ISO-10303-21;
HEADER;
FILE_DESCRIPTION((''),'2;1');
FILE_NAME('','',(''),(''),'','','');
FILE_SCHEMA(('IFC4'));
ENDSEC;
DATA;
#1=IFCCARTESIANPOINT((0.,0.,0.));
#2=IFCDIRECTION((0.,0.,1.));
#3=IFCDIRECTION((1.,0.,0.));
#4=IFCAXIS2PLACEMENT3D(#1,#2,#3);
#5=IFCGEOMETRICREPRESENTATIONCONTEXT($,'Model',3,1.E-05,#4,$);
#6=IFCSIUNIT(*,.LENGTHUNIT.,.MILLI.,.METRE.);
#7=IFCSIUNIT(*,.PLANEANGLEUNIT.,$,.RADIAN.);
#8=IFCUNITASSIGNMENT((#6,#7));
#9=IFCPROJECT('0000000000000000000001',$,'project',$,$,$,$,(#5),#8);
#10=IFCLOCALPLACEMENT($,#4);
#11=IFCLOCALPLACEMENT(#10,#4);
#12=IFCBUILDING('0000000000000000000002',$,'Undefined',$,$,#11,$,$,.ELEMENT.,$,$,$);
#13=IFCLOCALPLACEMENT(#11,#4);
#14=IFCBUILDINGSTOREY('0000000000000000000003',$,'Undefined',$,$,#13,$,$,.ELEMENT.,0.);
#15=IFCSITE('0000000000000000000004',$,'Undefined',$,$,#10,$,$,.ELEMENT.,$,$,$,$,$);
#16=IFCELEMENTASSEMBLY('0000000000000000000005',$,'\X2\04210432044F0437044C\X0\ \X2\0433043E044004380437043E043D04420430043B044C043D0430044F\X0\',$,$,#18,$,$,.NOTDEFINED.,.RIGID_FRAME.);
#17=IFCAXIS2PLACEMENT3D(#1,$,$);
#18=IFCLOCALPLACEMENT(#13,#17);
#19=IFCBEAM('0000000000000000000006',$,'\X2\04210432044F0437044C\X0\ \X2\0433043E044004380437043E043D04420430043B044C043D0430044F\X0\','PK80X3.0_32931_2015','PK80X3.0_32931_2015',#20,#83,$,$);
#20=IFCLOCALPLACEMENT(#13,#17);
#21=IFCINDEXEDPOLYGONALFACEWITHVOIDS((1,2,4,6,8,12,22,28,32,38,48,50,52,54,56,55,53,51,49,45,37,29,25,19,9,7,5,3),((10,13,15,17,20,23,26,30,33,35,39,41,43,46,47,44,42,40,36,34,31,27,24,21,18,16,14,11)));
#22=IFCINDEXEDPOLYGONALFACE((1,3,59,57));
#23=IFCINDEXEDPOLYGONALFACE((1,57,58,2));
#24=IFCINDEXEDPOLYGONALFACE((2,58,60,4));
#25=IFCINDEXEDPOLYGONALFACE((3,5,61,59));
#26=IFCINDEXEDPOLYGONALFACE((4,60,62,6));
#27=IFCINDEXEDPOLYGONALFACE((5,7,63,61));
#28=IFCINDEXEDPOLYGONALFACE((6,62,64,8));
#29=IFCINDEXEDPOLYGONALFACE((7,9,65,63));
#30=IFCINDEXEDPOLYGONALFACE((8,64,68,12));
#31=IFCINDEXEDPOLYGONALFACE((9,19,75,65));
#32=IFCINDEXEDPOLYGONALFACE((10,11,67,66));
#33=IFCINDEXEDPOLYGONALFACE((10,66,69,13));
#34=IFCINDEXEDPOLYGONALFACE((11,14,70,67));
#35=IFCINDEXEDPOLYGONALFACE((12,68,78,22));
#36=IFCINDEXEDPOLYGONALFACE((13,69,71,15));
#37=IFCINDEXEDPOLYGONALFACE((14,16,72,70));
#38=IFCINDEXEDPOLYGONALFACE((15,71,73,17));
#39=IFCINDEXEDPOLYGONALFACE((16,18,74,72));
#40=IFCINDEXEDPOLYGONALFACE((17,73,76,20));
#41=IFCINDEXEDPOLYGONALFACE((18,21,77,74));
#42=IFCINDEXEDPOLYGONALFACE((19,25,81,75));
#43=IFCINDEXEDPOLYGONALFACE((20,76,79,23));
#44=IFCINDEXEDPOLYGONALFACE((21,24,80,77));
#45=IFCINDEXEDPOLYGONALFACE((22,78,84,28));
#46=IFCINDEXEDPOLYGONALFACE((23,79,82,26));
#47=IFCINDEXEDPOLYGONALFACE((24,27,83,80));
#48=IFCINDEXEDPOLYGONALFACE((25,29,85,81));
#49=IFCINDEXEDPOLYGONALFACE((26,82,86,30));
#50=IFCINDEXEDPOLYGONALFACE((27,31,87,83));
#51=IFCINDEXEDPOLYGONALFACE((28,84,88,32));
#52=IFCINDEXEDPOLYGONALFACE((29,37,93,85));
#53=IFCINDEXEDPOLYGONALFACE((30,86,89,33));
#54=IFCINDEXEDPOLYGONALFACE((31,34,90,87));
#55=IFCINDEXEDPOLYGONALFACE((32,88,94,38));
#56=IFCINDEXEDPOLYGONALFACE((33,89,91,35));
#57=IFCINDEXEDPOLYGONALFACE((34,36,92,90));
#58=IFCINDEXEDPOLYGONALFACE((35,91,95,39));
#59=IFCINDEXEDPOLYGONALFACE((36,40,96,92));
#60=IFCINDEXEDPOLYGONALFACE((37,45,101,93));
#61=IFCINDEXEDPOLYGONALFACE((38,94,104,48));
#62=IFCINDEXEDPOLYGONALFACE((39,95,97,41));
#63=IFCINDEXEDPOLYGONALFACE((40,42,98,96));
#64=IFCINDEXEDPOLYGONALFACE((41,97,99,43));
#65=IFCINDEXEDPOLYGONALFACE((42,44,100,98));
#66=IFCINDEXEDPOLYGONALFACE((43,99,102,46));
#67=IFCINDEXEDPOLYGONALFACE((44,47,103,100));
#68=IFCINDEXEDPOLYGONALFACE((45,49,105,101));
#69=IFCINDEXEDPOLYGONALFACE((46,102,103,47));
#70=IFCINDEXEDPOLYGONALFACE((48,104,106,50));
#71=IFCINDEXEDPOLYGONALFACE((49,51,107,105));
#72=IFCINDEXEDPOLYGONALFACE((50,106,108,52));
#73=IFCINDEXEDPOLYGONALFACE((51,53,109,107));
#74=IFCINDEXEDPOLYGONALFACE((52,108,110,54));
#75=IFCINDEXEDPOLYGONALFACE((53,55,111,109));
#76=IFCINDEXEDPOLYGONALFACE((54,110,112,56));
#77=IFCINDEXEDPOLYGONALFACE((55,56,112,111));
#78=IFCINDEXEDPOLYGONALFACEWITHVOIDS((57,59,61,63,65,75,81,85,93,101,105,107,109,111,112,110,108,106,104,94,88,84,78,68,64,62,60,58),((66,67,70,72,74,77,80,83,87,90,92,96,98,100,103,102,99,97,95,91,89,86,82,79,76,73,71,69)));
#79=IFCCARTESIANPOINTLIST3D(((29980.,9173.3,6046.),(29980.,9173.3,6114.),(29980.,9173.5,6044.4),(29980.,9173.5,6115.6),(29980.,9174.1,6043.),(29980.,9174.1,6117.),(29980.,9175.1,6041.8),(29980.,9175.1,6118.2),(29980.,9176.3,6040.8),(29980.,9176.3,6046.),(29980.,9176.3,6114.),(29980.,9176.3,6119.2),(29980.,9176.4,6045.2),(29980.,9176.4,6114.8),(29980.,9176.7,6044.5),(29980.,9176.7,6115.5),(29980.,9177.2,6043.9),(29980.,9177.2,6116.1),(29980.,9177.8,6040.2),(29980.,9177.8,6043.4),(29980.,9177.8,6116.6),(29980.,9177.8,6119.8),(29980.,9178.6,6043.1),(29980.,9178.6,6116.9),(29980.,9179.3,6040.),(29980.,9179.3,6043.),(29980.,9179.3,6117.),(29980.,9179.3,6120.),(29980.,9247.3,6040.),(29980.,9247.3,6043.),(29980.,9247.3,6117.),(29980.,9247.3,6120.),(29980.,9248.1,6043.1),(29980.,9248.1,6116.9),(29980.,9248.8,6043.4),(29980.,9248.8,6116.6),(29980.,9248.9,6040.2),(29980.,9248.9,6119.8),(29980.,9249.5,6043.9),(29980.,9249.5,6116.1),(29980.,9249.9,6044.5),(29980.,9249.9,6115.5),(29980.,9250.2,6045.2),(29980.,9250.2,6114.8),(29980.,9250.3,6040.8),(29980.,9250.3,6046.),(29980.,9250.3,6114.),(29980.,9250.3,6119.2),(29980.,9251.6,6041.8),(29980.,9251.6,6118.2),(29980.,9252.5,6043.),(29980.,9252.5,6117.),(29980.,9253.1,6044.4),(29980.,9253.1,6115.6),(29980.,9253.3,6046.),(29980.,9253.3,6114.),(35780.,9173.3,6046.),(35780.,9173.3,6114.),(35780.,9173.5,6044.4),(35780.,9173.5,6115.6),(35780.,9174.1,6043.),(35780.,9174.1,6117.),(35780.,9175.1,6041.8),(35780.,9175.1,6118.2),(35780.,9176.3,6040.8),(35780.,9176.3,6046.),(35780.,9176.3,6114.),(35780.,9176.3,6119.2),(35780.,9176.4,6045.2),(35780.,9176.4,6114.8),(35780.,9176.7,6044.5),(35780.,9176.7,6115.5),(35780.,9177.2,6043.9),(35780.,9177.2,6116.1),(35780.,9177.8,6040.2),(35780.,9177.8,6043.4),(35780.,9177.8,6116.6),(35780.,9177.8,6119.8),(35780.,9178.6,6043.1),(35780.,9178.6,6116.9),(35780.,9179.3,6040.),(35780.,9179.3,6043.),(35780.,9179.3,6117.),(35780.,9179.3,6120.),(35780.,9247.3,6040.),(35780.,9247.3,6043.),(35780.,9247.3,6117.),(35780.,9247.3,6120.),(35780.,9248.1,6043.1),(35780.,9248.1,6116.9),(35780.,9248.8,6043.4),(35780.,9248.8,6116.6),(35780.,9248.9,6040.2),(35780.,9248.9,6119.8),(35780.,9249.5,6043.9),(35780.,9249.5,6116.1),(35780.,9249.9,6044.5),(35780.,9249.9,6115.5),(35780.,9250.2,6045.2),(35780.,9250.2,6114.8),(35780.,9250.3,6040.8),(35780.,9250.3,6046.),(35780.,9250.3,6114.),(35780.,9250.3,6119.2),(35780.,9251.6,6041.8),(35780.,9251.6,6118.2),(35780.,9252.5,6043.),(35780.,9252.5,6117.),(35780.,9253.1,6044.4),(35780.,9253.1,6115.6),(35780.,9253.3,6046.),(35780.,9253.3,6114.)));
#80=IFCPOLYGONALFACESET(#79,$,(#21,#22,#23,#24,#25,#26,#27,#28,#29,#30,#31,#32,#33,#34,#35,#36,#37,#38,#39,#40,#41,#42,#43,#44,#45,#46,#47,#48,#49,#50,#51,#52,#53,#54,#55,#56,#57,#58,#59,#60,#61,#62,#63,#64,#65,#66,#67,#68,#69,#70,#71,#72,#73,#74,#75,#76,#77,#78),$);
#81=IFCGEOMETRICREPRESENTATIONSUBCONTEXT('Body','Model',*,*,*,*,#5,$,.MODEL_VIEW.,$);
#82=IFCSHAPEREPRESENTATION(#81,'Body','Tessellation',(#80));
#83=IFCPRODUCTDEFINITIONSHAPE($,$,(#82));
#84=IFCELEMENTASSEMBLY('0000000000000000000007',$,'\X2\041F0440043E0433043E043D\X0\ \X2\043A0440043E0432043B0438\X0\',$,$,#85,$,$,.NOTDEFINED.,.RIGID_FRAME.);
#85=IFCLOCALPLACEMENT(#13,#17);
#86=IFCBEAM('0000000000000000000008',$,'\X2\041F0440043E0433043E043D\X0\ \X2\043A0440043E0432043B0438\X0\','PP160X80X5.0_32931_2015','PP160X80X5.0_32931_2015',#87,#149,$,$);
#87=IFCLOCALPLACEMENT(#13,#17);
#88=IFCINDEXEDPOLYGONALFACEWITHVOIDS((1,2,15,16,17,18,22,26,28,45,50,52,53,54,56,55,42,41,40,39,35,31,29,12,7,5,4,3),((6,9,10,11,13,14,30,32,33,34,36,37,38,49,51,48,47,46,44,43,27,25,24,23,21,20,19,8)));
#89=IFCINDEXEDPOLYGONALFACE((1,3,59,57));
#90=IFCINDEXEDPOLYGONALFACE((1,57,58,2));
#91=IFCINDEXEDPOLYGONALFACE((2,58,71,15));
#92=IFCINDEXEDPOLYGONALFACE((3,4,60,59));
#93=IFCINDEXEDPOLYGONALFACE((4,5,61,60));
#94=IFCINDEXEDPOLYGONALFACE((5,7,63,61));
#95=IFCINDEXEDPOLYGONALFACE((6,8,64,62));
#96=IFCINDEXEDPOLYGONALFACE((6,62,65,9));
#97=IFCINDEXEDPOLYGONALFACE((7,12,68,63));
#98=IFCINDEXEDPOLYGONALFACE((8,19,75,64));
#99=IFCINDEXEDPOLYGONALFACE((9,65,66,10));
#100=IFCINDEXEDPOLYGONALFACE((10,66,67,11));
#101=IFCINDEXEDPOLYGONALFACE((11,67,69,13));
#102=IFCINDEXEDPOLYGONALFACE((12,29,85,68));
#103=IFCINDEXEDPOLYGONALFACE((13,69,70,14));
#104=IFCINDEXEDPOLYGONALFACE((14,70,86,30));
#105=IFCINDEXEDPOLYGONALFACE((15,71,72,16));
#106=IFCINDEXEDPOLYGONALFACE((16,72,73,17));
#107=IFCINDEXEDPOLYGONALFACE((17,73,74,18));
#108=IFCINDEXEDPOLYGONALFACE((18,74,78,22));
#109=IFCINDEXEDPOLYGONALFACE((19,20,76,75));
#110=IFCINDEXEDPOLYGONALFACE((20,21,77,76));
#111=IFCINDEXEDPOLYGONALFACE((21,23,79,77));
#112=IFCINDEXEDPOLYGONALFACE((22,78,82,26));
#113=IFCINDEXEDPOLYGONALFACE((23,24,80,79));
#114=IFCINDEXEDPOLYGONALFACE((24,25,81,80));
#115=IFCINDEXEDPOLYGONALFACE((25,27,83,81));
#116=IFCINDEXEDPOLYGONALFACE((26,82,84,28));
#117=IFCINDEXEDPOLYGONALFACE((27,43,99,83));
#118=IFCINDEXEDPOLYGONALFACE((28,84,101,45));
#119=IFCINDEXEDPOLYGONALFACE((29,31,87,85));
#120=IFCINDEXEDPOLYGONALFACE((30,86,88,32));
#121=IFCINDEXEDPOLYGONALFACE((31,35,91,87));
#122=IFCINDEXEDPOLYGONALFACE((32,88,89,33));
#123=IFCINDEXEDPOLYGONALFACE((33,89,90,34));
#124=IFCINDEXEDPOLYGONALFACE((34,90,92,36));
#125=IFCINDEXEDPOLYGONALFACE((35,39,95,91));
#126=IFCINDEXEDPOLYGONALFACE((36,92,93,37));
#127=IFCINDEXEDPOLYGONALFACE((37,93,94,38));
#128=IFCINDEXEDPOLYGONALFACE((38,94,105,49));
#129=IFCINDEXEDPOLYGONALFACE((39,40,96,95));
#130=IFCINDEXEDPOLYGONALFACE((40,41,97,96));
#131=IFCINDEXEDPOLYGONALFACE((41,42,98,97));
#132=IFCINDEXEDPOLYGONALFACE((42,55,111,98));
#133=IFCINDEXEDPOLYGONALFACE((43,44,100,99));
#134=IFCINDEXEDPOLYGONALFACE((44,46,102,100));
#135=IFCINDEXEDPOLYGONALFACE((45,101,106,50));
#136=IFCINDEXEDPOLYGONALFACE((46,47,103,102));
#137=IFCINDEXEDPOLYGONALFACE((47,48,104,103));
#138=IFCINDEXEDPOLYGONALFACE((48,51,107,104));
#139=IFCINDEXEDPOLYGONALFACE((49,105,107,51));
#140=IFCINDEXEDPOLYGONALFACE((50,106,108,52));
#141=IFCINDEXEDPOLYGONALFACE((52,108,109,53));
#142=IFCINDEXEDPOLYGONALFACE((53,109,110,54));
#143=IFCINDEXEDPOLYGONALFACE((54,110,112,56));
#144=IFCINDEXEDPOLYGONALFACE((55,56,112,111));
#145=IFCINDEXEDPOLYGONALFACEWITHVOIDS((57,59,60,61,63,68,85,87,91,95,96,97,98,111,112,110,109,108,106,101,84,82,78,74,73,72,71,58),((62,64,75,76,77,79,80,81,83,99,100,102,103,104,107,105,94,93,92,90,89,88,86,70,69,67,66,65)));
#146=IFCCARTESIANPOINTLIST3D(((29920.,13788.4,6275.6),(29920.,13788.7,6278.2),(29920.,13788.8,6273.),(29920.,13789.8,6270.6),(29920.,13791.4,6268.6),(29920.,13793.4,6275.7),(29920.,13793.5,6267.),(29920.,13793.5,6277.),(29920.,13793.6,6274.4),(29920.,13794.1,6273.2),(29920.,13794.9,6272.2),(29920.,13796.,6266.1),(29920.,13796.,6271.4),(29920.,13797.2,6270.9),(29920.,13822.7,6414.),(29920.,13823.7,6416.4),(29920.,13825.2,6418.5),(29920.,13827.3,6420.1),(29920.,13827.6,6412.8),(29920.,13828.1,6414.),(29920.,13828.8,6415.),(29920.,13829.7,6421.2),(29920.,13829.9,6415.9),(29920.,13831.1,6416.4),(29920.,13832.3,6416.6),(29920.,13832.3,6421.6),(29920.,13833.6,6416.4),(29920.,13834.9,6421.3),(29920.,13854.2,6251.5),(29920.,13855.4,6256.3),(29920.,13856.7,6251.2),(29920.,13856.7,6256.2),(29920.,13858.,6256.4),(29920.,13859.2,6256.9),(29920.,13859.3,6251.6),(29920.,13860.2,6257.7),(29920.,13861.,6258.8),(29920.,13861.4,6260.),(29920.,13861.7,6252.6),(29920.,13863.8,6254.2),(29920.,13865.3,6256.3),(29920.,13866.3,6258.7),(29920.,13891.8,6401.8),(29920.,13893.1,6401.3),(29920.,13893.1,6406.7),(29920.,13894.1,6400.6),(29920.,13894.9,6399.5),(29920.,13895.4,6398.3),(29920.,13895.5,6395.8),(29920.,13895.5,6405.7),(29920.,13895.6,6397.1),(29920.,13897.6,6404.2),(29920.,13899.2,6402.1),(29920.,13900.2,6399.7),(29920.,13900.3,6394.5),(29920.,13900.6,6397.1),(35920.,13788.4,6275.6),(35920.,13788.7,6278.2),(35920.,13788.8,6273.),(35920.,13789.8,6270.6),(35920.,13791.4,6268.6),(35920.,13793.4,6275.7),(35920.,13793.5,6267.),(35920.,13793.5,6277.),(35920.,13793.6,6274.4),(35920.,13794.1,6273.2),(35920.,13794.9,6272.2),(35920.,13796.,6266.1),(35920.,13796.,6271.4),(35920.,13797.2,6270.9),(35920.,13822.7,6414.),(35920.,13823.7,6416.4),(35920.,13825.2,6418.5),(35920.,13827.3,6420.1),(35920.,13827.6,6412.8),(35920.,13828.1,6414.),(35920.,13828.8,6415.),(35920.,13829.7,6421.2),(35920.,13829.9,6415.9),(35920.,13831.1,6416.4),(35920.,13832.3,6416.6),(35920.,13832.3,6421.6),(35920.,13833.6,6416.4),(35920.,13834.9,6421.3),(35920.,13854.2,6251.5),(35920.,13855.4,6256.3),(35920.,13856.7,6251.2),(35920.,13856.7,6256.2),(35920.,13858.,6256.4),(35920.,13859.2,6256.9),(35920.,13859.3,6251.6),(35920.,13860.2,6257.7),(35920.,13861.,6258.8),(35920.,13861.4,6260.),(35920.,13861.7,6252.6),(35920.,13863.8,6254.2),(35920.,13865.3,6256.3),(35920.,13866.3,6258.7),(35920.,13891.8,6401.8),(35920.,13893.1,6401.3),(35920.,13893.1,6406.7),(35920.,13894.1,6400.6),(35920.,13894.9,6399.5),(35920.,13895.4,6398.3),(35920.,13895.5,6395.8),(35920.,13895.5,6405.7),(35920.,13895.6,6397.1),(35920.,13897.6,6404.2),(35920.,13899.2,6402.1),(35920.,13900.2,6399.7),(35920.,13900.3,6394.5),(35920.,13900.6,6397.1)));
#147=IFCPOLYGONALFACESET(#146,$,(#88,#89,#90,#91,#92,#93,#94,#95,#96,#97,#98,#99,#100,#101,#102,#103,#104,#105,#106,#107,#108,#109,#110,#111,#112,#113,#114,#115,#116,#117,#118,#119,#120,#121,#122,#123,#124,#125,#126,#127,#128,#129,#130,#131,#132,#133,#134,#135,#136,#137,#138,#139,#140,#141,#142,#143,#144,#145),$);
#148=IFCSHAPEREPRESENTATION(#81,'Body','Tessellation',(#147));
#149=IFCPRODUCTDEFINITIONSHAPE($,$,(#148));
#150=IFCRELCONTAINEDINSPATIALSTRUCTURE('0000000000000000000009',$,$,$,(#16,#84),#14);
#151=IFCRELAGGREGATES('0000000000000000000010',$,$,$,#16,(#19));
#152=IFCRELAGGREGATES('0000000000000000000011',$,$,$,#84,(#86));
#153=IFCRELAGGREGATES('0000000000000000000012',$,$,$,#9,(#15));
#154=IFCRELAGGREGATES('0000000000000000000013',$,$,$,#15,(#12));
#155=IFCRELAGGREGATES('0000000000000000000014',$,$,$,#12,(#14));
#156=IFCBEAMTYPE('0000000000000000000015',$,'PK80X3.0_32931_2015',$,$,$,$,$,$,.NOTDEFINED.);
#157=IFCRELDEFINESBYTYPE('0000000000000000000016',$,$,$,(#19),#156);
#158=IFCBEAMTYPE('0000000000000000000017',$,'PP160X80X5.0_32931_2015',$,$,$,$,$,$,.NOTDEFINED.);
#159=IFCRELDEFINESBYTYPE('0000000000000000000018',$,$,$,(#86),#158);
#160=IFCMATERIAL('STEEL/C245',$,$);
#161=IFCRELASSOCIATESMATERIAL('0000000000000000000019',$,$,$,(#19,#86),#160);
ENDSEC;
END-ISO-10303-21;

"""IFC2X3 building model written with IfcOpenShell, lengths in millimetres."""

from ifc_helpers import new_model, si_unit, frame, origin_with_axes, origin_2d_with_axis, place, context, subcontext, project, spatial, hollow_rectangle, extrude, material, type_object, element, aggregate, save


model = new_model("IFC2X3")

# Units and contexts
model_context = context("Model", 3, precision=1e-05, world=origin_with_axes())
body_context = subcontext(model_context, "Body", "Model", "MODEL_VIEW")
ifc_project = project(units=[si_unit("LENGTHUNIT", "METRE", prefix="MILLI"), si_unit("PLANEANGLEUNIT", "RADIAN")], contexts=[model_context])

# Site, building, storey
site_placement = place(None, origin_with_axes())
site = spatial("IfcSite", under=ifc_project, at=site_placement, Name="Undefined", CompositionType="ELEMENT")
building_placement = place(site_placement, origin_with_axes())
building = spatial("IfcBuilding", under=site, at=building_placement, Name="Undefined", CompositionType="ELEMENT")
storey_placement = place(building_placement, origin_with_axes())
storey = spatial("IfcBuildingStorey", under=building, at=storey_placement, Name="Undefined", CompositionType="ELEMENT", Elevation=0.0)

# Shared definitions
ifc_material = material(Name="STEEL/C245")

# Element assemblies, beams
beam_type_1 = type_object("IfcBeamType", Name="PK80X3.0_32931_2015", PredefinedType="NOTDEFINED")
assembly_1_placement = place(storey_placement, origin_with_axes())
assembly_1 = element("IfcElementAssembly", 1, at=assembly_1_placement, inside=storey, Name="Связь горизонтальная", AssemblyPlace="NOTDEFINED", PredefinedType="RIGID_FRAME")
beam_1_placement = place(assembly_1_placement, frame((29980.0, 9213.3, 6080.0), z_axis=(0.0, 0.0, 1.0), x_axis=(1.0, 0.0, 0.0)))
beam_1 = element("IfcBeam", 2, at=beam_1_placement, type_object=beam_type_1, material=ifc_material, Name="Связь горизонтальная", Description="PK80X3.0_32931_2015", ObjectType="PK80X3.0_32931_2015", context=body_context, shape_type="SweptSolid", body=[
    extrude(hollow_rectangle(XDim=80.0, YDim=80.0, WallThickness=3.0, InnerFilletRadius=3.0, OuterFilletRadius=6.0, at=origin_2d_with_axis()), frame((5800.0, 0.0, 0.0), z_axis=(-1.0, 0.0, 0.0), x_axis=(0.0, -1.0, 0.0)), (0.0, 0.0, 1.0), 5800.0),
])
aggregate(assembly_1, [beam_1])
assembly_2_placement = place(storey_placement, origin_with_axes())
assembly_2 = element("IfcElementAssembly", 3, at=assembly_2_placement, inside=storey, Name="Прогон кровли", AssemblyPlace="NOTDEFINED", PredefinedType="RIGID_FRAME")
beam_type_2 = type_object("IfcBeamType", Name="PP160X80X5.0_32931_2015", PredefinedType="NOTDEFINED")
beam_2_placement = place(assembly_2_placement, frame((29920.0, 13844.5, 6336.4), z_axis=(0.0, 0.243188, 0.969979), x_axis=(1.0, 0.0, 0.0)))
beam_2 = element("IfcBeam", 4, at=beam_2_placement, type_object=beam_type_2, material=ifc_material, Name="Прогон кровли", Description="PP160X80X5.0_32931_2015", ObjectType="PP160X80X5.0_32931_2015", context=body_context, shape_type="SweptSolid", body=[
    extrude(hollow_rectangle(XDim=80.0, YDim=160.0, WallThickness=5.0, InnerFilletRadius=5.0, OuterFilletRadius=10.0, at=origin_2d_with_axis()), frame((6000.0, 0.0, 0.0), z_axis=(-1.0, 0.0, 0.0), x_axis=(0.0, -1.0, 0.0)), (0.0, 0.0, 1.0), 6000.0),
])
aggregate(assembly_2, [beam_2])

save(model, "model.ifc")
